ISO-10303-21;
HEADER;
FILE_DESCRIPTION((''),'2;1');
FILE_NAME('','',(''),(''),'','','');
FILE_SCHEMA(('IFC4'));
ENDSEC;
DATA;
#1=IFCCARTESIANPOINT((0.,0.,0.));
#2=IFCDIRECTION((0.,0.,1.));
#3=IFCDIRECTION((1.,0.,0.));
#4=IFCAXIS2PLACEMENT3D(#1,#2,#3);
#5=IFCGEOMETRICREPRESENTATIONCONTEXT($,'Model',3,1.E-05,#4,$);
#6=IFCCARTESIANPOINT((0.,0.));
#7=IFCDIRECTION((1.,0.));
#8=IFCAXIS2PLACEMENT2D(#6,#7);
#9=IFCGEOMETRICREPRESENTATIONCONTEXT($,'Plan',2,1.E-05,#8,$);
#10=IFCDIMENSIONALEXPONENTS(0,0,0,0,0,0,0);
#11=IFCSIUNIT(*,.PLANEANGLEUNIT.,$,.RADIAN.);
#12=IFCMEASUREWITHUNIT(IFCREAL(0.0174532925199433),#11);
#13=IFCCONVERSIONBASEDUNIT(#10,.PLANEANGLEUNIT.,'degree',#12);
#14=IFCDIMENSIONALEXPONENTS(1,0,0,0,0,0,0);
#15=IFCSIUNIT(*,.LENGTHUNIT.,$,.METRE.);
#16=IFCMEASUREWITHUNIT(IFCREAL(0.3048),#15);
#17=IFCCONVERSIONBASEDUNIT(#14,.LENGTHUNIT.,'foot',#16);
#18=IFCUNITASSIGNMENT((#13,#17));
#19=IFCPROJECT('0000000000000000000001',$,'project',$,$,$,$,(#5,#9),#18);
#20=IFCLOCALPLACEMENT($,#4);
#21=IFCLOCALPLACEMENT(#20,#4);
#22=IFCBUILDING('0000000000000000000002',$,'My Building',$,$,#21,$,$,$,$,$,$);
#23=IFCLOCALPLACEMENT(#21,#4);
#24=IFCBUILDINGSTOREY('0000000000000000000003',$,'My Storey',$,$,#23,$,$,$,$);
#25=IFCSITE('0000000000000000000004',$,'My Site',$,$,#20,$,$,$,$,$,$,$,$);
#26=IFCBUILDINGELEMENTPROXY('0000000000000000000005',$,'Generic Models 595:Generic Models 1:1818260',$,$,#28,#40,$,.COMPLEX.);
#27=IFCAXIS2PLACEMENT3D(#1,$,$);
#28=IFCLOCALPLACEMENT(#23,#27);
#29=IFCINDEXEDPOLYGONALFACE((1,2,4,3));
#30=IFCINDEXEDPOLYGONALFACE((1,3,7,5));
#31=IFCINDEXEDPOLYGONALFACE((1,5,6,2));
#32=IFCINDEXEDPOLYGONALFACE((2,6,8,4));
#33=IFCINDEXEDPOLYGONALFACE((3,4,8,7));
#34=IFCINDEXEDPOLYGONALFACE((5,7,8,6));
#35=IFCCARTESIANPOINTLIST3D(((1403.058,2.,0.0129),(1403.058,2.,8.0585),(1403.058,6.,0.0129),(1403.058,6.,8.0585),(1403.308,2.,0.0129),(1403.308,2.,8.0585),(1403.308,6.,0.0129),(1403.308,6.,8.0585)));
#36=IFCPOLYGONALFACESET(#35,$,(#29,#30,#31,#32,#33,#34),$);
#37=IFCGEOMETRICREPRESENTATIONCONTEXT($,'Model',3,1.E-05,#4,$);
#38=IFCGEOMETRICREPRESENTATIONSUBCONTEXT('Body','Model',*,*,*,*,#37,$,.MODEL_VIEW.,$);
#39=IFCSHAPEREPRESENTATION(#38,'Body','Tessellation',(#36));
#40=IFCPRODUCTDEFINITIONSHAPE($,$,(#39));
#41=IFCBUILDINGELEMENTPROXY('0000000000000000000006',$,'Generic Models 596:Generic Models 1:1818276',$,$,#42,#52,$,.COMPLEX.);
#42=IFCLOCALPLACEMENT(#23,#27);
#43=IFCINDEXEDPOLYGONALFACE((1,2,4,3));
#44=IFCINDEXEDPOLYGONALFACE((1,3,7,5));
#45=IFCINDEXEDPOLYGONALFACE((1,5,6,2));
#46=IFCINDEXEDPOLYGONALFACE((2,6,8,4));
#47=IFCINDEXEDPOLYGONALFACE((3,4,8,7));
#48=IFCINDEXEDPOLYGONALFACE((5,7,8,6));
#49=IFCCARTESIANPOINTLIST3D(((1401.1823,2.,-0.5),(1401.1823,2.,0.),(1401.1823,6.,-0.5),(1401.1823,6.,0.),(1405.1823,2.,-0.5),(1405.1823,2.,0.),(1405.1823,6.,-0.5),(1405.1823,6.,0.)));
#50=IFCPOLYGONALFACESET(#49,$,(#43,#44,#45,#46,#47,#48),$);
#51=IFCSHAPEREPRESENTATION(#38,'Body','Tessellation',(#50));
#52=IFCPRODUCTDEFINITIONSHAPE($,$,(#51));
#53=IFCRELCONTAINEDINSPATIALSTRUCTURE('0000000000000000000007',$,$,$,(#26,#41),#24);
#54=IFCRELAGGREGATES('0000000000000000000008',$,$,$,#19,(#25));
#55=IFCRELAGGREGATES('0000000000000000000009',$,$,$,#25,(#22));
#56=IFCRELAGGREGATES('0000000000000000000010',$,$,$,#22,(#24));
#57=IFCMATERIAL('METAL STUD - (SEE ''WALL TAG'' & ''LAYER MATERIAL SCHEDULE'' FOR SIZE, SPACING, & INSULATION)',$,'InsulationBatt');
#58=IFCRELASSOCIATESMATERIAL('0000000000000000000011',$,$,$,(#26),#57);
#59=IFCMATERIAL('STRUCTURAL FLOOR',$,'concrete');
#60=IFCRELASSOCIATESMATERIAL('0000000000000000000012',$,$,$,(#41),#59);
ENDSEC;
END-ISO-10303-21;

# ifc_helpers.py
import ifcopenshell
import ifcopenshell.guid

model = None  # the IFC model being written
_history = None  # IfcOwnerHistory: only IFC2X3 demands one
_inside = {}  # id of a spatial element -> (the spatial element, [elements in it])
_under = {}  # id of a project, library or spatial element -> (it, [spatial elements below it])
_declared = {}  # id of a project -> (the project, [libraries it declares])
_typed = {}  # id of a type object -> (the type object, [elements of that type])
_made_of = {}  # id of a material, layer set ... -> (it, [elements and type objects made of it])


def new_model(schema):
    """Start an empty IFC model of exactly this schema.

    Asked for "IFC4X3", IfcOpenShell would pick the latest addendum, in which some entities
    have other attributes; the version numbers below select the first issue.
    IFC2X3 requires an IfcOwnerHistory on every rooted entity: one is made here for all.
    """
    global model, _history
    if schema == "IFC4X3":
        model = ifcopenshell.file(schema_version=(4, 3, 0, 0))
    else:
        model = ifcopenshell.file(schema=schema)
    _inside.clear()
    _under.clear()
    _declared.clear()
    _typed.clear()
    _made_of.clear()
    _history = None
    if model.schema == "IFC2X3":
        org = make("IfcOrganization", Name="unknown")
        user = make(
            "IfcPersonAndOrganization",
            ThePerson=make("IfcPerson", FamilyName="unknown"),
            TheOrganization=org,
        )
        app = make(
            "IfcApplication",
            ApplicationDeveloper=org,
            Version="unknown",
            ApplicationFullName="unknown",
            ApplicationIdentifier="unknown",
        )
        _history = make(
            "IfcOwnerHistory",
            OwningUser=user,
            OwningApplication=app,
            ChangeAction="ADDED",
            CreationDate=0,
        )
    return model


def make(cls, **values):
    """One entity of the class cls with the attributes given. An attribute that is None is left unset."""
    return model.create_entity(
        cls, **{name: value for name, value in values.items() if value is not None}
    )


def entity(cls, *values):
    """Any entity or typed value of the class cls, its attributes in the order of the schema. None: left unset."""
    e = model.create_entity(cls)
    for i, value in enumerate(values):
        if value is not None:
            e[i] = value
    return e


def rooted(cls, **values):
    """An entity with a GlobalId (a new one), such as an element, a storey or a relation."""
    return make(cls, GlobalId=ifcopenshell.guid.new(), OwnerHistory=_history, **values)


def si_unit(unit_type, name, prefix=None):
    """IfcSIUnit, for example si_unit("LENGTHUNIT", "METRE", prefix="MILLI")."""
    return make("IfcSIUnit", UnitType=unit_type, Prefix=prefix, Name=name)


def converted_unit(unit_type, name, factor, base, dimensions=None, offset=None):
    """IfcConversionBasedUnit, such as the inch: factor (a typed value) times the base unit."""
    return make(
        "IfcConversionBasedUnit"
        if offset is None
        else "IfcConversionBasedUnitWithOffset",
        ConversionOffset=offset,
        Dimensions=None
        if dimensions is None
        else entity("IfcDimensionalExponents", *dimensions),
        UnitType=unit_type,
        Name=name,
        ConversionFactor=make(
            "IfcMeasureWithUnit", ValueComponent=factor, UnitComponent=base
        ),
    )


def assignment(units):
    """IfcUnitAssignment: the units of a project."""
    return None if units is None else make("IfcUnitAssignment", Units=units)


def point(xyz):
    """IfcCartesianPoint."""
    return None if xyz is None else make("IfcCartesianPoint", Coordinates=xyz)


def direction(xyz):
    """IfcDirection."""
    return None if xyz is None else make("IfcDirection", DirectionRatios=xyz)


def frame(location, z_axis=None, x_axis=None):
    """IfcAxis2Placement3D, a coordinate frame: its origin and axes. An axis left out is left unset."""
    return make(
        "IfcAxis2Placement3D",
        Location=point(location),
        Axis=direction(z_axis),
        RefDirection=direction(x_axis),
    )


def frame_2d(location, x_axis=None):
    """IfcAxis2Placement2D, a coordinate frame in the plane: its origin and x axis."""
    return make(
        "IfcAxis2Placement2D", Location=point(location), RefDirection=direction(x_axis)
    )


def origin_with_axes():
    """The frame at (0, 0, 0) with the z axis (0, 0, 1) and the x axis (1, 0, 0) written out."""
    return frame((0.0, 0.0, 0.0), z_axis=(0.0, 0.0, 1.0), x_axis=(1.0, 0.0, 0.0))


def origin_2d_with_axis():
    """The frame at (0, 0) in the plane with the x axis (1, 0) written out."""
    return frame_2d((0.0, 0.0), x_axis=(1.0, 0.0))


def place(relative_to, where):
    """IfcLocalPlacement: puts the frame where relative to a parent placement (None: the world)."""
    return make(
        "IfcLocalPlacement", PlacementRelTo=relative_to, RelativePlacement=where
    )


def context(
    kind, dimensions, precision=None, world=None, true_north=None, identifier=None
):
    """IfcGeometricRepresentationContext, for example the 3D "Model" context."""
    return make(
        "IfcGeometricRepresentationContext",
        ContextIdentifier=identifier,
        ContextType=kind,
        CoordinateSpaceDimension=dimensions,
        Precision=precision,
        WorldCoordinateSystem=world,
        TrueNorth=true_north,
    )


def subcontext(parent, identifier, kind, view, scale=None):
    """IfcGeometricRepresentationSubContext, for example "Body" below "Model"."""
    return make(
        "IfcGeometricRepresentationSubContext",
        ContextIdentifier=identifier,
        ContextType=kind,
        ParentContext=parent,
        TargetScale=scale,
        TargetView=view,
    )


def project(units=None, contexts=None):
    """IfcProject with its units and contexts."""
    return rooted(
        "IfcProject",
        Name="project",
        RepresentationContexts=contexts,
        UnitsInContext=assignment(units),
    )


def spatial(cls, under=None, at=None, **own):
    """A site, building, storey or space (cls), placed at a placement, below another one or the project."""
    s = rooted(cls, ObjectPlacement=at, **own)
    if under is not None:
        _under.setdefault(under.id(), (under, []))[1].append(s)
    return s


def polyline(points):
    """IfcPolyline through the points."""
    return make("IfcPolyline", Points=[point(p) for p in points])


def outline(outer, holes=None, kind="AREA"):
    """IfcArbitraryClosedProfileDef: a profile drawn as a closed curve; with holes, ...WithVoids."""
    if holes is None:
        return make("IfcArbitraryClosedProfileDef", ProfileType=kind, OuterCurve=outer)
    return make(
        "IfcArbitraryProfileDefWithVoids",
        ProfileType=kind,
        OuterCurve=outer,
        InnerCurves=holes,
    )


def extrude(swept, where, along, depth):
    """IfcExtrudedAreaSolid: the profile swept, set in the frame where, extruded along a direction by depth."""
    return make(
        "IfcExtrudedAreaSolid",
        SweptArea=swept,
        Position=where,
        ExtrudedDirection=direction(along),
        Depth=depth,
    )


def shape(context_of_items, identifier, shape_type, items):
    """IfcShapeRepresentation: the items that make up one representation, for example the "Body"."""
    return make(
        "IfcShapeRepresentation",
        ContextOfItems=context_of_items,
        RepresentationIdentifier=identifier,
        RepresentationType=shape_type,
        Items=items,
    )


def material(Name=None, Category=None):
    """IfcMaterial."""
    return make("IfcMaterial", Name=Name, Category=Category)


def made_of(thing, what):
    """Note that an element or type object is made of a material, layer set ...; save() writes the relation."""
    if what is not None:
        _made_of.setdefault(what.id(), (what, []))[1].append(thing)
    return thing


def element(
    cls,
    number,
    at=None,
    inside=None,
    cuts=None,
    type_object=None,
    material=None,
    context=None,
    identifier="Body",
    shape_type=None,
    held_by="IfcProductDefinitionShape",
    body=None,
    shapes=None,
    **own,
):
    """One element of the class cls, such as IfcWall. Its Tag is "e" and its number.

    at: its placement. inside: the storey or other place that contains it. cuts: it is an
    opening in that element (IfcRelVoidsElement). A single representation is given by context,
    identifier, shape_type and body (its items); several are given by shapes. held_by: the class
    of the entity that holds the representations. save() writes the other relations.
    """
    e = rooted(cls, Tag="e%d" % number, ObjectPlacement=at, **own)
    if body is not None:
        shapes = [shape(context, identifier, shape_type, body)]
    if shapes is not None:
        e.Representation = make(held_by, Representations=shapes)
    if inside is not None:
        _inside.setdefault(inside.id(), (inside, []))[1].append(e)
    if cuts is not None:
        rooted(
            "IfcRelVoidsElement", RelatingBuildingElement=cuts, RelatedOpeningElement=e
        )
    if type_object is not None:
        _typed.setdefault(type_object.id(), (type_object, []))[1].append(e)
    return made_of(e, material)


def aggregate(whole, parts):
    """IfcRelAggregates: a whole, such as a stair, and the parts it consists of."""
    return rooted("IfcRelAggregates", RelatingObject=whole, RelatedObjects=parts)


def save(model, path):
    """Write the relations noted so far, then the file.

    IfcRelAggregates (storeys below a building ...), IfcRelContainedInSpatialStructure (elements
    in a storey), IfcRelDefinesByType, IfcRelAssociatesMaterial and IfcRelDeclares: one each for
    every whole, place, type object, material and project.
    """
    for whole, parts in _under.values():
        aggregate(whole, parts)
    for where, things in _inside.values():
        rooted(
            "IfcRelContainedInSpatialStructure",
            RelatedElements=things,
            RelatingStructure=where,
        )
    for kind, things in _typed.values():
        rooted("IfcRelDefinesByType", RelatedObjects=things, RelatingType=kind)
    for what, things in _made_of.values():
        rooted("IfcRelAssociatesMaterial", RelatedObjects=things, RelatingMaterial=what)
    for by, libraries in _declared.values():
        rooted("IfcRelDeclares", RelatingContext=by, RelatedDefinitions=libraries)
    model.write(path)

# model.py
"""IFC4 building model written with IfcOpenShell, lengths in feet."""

from ifc_helpers import new_model, entity, si_unit, converted_unit, frame, origin_with_axes, origin_2d_with_axis, place, context, subcontext, project, spatial, polyline, outline, extrude, material, element, save


model = new_model("IFC4")

# Units and contexts
model_context_1 = context("Model", 3, precision=1e-05, world=origin_with_axes())
plan_context = context("Plan", 2, precision=1e-05, world=origin_2d_with_axis())
model_context_2 = context("Model", 3, precision=1e-05, world=origin_with_axes())
body_context = subcontext(model_context_2, "Body", "Model", "MODEL_VIEW")
ifc_project = project(units=[converted_unit("PLANEANGLEUNIT", "degree", entity("IfcReal", 0.0174532925199433), si_unit("PLANEANGLEUNIT", "RADIAN"), dimensions=[0, 0, 0, 0, 0, 0, 0]), converted_unit("LENGTHUNIT", "foot", entity("IfcReal", 0.3048), si_unit("LENGTHUNIT", "METRE"), dimensions=[1, 0, 0, 0, 0, 0, 0])], contexts=[model_context_1, plan_context])

# Site, building, storey
site_placement = place(None, origin_with_axes())
site = spatial("IfcSite", under=ifc_project, at=site_placement, Name="My Site")
building_placement = place(site_placement, origin_with_axes())
building = spatial("IfcBuilding", under=site, at=building_placement, Name="My Building")
storey_placement = place(building_placement, origin_with_axes())
storey = spatial("IfcBuildingStorey", under=building, at=storey_placement, Name="My Storey")

# Building element proxies
ifc_material_1 = material(Name="METAL STUD - (SEE 'WALL TAG' & 'LAYER MATERIAL SCHEDULE' FOR SIZE, SPACING, & INSULATION)", Category="InsulationBatt")
proxy_1_placement = place(storey_placement, frame((1403.058, 6.0, 0.0129), z_axis=(0.0, -1.0, 0.0), x_axis=(0.0, 0.0, 1.0)))
element("IfcBuildingElementProxy", 1, at=proxy_1_placement, inside=storey, material=ifc_material_1, Name="Generic Models 595:Generic Models 1:1818260", PredefinedType="COMPLEX", context=body_context, shape_type="SweptSolid", body=[
    extrude(outline(polyline([(-4.0228, -0.125), (4.0228, -0.125), (4.0228, 0.125), (-4.0228, 0.125), (-4.0228, -0.125)])), frame((4.0228, -0.125, 0.0), z_axis=(0.0, 0.0, -1.0), x_axis=(1.0, 0.0, 0.0)), (0.0, 0.0, -1.0), 4.0),
])
ifc_material_2 = material(Name="STRUCTURAL FLOOR", Category="concrete")
proxy_2_placement = place(storey_placement, frame((1401.1823, 6.0, -0.5), z_axis=(0.0, -1.0, 0.0), x_axis=(0.0, 0.0, 1.0)))
element("IfcBuildingElementProxy", 2, at=proxy_2_placement, inside=storey, material=ifc_material_2, Name="Generic Models 596:Generic Models 1:1818276", PredefinedType="COMPLEX", context=body_context, shape_type="SweptSolid", body=[
    extrude(outline(polyline([(-0.25, -2.0), (0.25, -2.0), (0.25, 2.0), (-0.25, 2.0), (-0.25, -2.0)])), frame((0.25, -2.0, 0.0), z_axis=(0.0, 0.0, -1.0), x_axis=(-1.0, 0.0, 0.0)), (0.0, 0.0, -1.0), 4.0),
])

save(model, "model.ifc")
